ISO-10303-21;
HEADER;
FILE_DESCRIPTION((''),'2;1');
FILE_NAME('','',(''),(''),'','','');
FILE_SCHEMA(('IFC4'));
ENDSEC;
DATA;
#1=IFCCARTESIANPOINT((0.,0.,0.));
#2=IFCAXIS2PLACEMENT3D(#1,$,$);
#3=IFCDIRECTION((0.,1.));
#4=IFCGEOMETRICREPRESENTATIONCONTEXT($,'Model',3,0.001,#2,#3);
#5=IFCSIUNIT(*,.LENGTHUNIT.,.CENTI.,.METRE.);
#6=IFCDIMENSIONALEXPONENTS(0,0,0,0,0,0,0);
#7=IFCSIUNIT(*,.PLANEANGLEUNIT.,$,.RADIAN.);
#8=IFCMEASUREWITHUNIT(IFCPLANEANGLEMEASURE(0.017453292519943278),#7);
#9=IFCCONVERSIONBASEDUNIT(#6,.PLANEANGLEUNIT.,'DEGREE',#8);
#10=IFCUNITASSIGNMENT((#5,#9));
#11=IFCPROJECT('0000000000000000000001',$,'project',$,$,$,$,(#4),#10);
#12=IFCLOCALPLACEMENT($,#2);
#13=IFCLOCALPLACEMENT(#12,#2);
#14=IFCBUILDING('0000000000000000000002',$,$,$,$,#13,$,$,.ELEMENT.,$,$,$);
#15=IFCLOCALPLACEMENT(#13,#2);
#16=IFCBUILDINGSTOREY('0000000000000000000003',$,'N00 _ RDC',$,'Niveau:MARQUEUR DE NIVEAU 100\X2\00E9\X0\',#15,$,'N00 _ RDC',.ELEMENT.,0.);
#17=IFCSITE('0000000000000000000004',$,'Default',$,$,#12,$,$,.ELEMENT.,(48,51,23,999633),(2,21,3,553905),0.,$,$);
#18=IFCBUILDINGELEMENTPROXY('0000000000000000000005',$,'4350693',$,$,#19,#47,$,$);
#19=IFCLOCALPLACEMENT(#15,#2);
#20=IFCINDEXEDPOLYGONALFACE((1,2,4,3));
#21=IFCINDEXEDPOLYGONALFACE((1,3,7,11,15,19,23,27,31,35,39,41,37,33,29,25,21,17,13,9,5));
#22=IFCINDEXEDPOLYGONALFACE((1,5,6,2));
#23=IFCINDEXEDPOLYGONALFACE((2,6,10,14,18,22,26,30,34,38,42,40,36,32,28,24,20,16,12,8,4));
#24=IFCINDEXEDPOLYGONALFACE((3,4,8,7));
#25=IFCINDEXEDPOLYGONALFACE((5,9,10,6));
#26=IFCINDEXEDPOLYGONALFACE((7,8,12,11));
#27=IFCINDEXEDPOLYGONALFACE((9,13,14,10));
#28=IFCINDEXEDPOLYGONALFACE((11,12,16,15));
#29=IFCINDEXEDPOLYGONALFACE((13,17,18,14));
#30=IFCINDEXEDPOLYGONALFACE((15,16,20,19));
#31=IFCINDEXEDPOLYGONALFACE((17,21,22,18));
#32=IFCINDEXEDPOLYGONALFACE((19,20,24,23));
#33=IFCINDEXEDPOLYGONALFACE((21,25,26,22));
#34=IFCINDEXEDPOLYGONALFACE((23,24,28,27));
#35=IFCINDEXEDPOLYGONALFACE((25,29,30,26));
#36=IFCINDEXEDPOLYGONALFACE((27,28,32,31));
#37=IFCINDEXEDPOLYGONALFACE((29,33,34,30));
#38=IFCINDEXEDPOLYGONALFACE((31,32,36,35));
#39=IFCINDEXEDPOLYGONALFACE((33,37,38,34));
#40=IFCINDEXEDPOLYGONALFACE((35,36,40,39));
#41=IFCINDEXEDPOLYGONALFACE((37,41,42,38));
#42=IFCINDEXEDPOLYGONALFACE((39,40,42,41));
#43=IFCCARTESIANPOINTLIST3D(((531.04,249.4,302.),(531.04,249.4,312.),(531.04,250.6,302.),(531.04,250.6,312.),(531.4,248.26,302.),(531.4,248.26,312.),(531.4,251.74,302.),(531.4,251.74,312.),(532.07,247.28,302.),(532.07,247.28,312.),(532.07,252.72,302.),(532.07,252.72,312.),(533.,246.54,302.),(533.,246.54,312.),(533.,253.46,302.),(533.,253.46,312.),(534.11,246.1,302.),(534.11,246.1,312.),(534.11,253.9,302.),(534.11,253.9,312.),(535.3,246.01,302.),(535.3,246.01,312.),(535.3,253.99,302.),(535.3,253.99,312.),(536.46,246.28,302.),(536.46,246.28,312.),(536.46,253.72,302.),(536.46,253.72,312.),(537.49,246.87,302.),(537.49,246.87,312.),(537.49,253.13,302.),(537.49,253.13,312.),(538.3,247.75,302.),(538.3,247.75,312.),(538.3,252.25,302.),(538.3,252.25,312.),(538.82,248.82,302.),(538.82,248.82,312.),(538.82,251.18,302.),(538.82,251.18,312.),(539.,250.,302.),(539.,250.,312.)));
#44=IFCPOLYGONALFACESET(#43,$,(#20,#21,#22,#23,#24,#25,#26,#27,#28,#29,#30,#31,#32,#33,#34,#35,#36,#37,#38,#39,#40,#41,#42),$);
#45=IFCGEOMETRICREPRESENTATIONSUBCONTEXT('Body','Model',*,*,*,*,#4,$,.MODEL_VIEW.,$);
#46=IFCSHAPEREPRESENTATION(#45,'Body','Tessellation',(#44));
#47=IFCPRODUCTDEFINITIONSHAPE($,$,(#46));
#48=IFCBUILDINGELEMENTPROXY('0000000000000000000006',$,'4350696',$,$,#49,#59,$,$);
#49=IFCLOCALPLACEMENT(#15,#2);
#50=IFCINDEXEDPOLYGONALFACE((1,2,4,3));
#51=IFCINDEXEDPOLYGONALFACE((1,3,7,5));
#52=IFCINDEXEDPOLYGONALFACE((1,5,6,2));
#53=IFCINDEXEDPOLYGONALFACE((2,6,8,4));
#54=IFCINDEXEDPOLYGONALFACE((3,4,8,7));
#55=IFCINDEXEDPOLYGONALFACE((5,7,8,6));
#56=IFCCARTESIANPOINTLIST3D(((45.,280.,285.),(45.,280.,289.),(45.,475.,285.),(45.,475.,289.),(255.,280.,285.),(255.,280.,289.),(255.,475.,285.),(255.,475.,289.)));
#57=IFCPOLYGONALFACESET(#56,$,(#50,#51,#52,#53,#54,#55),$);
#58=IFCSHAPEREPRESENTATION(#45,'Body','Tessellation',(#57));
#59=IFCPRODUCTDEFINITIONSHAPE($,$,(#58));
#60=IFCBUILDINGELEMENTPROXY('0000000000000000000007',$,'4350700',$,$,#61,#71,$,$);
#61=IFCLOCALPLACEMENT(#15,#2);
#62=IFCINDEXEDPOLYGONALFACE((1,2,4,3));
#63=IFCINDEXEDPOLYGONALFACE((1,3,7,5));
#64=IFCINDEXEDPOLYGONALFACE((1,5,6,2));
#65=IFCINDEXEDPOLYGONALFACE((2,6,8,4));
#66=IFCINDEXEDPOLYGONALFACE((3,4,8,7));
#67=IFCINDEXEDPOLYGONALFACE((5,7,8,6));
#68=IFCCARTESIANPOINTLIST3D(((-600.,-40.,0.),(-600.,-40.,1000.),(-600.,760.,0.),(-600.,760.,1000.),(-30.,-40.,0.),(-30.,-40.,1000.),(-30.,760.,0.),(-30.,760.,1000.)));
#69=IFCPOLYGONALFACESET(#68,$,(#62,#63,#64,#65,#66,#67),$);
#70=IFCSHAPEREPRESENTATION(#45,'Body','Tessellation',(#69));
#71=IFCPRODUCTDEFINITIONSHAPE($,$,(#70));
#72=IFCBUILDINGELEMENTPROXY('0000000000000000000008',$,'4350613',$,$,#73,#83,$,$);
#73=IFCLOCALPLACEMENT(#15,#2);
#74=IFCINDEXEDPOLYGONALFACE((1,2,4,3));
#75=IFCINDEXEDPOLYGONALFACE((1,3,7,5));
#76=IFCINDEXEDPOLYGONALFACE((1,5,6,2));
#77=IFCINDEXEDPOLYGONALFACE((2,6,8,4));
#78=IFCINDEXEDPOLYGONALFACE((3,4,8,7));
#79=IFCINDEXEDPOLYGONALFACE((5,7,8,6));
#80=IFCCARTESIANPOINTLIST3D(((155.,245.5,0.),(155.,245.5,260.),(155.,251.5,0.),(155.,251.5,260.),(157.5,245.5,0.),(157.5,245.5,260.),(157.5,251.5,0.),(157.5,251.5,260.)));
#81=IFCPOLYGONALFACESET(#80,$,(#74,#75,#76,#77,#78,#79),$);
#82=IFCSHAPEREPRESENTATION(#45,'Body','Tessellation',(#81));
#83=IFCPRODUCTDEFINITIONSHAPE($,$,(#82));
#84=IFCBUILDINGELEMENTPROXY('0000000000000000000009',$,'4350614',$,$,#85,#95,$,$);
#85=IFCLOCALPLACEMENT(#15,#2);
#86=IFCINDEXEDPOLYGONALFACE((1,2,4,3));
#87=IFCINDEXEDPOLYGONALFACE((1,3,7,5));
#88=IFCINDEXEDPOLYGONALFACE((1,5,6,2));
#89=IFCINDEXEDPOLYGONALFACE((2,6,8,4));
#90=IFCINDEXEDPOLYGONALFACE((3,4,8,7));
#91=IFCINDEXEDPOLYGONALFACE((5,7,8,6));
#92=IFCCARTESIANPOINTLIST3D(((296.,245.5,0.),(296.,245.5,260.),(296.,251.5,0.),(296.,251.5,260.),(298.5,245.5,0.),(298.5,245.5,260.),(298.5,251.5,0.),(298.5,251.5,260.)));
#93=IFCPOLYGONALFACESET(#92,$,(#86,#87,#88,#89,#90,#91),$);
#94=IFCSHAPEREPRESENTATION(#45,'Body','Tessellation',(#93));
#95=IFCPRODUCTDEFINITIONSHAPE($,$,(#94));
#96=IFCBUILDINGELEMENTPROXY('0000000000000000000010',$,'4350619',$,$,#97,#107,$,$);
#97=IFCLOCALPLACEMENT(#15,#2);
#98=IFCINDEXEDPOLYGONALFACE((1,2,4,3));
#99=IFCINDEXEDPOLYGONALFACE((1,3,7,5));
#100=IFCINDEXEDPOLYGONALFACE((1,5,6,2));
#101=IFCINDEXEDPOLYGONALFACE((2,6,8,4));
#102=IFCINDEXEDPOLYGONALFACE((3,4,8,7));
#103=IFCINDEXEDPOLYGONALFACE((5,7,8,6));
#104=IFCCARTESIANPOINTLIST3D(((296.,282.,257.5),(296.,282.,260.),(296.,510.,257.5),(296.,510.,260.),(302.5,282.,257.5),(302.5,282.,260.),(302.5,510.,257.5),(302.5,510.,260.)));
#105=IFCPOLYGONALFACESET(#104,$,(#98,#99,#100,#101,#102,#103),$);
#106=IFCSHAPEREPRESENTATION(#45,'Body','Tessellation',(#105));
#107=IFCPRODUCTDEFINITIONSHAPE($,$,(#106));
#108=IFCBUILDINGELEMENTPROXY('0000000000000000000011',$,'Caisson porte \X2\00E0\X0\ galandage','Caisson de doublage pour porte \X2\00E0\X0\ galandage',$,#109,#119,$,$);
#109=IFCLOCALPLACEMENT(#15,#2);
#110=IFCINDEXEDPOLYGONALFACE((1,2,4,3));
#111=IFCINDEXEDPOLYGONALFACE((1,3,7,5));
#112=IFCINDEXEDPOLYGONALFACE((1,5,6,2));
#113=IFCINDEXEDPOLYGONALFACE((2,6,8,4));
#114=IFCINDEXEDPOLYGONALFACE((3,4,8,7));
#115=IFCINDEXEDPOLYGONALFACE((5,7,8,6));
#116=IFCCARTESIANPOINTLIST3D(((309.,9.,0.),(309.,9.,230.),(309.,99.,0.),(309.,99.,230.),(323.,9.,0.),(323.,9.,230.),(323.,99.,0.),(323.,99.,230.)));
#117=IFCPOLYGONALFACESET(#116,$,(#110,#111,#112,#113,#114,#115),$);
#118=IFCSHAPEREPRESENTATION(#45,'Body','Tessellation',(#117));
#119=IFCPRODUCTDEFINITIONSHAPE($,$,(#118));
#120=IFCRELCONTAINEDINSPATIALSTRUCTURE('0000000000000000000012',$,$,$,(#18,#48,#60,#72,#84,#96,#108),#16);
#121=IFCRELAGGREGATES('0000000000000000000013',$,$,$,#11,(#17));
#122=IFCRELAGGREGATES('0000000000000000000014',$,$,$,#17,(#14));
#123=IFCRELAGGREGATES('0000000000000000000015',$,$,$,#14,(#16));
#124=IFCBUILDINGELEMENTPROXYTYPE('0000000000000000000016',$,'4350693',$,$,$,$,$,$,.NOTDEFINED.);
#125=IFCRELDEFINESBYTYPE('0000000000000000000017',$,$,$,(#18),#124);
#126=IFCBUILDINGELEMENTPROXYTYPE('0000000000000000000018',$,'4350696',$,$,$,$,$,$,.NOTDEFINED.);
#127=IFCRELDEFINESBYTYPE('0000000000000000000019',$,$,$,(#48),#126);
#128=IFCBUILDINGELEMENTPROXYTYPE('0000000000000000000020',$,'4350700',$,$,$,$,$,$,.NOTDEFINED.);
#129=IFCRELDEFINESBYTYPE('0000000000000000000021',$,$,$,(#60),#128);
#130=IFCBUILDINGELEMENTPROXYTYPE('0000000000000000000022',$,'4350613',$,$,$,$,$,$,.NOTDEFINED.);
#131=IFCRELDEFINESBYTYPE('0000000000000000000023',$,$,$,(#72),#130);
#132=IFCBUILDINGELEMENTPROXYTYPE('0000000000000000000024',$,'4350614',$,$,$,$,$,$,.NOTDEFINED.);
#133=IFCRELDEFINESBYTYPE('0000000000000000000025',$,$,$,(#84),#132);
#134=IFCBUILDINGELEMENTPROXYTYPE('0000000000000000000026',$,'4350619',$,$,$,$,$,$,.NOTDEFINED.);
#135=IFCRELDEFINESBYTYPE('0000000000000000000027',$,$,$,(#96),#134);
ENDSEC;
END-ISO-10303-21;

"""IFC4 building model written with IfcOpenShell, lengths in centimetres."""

from ifc_helpers import new_model, entity, si_unit, converted_unit, direction, frame, frame_2d, origin, origin_with_axes, origin_2d_with_axis, place, context, subcontext, project, spatial, rectangle, circle, extrude, type_object, element, save


model = new_model("IFC4")

# Units and contexts
model_context = context("Model", 3, precision=0.001, world=origin(), true_north=direction((0.0, 1.0)))
body_context = subcontext(model_context, "Body", "Model", "MODEL_VIEW")
ifc_project = project(units=[si_unit("LENGTHUNIT", "METRE", prefix="CENTI"), converted_unit("PLANEANGLEUNIT", "DEGREE", entity("IfcPlaneAngleMeasure", 0.017453292519943278), si_unit("PLANEANGLEUNIT", "RADIAN"), dimensions=[0, 0, 0, 0, 0, 0, 0])], contexts=[model_context])

# Site, building, storey
site_placement = place(None, origin())
site = spatial("IfcSite", under=ifc_project, at=site_placement, Name="Default", CompositionType="ELEMENT", RefLatitude=(48, 51, 23, 999633), RefLongitude=(2, 21, 3, 553905), RefElevation=0.0)
building_placement = place(site_placement, origin())
building = spatial("IfcBuilding", under=site, at=building_placement, CompositionType="ELEMENT")
storey_placement = place(building_placement, origin())
storey = spatial("IfcBuildingStorey", under=building, at=storey_placement, Name="N00 _ RDC", ObjectType="Niveau:MARQUEUR DE NIVEAU 100é", LongName="N00 _ RDC", CompositionType="ELEMENT", Elevation=0.0)

# Building element proxies
building_element_proxy_type_1 = type_object("IfcBuildingElementProxyType", Name="4350693", PredefinedType="NOTDEFINED")
proxy_1_placement = place(storey_placement, origin())
element("IfcBuildingElementProxy", 1, at=proxy_1_placement, inside=storey, type_object=building_element_proxy_type_1, Name="4350693", context=body_context, shape_type="SweptSolid", body=[
    extrude(circle(Radius=4.0, at=origin_2d_with_axis()), frame((535.0, 250.0, 302.0)), (0.0, 0.0, 1.0), 10.0),
])
building_element_proxy_type_2 = type_object("IfcBuildingElementProxyType", Name="4350696", PredefinedType="NOTDEFINED")
proxy_2_placement = place(storey_placement, origin())
element("IfcBuildingElementProxy", 2, at=proxy_2_placement, inside=storey, type_object=building_element_proxy_type_2, Name="4350696", context=body_context, shape_type="SweptSolid", body=[
    extrude(rectangle(XDim=210.0, YDim=195.0, at=frame_2d((0.0, 0.0), x_axis=(1.0, 0.0))), frame((150.0, 377.5, 285.0)), (0.0, 0.0, 1.0), 4.0),
])
building_element_proxy_type_3 = type_object("IfcBuildingElementProxyType", Name="4350700", PredefinedType="NOTDEFINED")
proxy_3_placement = place(storey_placement, origin())
element("IfcBuildingElementProxy", 3, at=proxy_3_placement, inside=storey, type_object=building_element_proxy_type_3, Name="4350700", context=body_context, shape_type="SweptSolid", body=[
    extrude(rectangle(XDim=570.0, YDim=800.0, at=origin_2d_with_axis()), frame((-315.0, 360.0, 0.0)), (0.0, 0.0, 1.0), 1000.0),
])
building_element_proxy_type_4 = type_object("IfcBuildingElementProxyType", Name="4350613", PredefinedType="NOTDEFINED")
proxy_4_placement = place(storey_placement, origin())
element("IfcBuildingElementProxy", 4, at=proxy_4_placement, inside=storey, type_object=building_element_proxy_type_4, Name="4350613", context=body_context, shape_type="SweptSolid", body=[
    extrude(rectangle(XDim=2.5, YDim=6.0, at=frame_2d((0.0, 0.0), x_axis=(1.0, 0.0))), frame((156.25, 248.5, 0.0)), (0.0, 0.0, 1.0), 260.0),
])
building_element_proxy_type_5 = type_object("IfcBuildingElementProxyType", Name="4350614", PredefinedType="NOTDEFINED")
proxy_5_placement = place(storey_placement, origin())
element("IfcBuildingElementProxy", 5, at=proxy_5_placement, inside=storey, type_object=building_element_proxy_type_5, Name="4350614", context=body_context, shape_type="SweptSolid", body=[
    extrude(rectangle(XDim=2.5, YDim=6.0, at=frame_2d((0.0, 0.0), x_axis=(1.0, 0.0))), frame((297.25, 248.5, 0.0)), (0.0, 0.0, 1.0), 260.0),
])
building_element_proxy_type_6 = type_object("IfcBuildingElementProxyType", Name="4350619", PredefinedType="NOTDEFINED")
proxy_6_placement = place(storey_placement, origin())
element("IfcBuildingElementProxy", 6, at=proxy_6_placement, inside=storey, type_object=building_element_proxy_type_6, Name="4350619", context=body_context, shape_type="SweptSolid", body=[
    extrude(rectangle(XDim=6.5, YDim=228.0, at=frame_2d((0.0, 0.0), x_axis=(1.0, 0.0))), frame((299.25, 396.0, 257.5)), (0.0, 0.0, 1.0), 2.5),
])
proxy_7_placement = place(storey_placement, origin_with_axes())
element("IfcBuildingElementProxy", 7, at=proxy_7_placement, inside=storey, Name="Caisson porte à galandage", Description="Caisson de doublage pour porte à galandage", context=body_context, shape_type="SweptSolid", body=[
    extrude(rectangle(XDim=14.0, YDim=90.0, at=frame_2d((316.0, 54.0))), origin(), (0.0, 0.0, 1.0), 230.0),
])

save(model, "model.ifc")
